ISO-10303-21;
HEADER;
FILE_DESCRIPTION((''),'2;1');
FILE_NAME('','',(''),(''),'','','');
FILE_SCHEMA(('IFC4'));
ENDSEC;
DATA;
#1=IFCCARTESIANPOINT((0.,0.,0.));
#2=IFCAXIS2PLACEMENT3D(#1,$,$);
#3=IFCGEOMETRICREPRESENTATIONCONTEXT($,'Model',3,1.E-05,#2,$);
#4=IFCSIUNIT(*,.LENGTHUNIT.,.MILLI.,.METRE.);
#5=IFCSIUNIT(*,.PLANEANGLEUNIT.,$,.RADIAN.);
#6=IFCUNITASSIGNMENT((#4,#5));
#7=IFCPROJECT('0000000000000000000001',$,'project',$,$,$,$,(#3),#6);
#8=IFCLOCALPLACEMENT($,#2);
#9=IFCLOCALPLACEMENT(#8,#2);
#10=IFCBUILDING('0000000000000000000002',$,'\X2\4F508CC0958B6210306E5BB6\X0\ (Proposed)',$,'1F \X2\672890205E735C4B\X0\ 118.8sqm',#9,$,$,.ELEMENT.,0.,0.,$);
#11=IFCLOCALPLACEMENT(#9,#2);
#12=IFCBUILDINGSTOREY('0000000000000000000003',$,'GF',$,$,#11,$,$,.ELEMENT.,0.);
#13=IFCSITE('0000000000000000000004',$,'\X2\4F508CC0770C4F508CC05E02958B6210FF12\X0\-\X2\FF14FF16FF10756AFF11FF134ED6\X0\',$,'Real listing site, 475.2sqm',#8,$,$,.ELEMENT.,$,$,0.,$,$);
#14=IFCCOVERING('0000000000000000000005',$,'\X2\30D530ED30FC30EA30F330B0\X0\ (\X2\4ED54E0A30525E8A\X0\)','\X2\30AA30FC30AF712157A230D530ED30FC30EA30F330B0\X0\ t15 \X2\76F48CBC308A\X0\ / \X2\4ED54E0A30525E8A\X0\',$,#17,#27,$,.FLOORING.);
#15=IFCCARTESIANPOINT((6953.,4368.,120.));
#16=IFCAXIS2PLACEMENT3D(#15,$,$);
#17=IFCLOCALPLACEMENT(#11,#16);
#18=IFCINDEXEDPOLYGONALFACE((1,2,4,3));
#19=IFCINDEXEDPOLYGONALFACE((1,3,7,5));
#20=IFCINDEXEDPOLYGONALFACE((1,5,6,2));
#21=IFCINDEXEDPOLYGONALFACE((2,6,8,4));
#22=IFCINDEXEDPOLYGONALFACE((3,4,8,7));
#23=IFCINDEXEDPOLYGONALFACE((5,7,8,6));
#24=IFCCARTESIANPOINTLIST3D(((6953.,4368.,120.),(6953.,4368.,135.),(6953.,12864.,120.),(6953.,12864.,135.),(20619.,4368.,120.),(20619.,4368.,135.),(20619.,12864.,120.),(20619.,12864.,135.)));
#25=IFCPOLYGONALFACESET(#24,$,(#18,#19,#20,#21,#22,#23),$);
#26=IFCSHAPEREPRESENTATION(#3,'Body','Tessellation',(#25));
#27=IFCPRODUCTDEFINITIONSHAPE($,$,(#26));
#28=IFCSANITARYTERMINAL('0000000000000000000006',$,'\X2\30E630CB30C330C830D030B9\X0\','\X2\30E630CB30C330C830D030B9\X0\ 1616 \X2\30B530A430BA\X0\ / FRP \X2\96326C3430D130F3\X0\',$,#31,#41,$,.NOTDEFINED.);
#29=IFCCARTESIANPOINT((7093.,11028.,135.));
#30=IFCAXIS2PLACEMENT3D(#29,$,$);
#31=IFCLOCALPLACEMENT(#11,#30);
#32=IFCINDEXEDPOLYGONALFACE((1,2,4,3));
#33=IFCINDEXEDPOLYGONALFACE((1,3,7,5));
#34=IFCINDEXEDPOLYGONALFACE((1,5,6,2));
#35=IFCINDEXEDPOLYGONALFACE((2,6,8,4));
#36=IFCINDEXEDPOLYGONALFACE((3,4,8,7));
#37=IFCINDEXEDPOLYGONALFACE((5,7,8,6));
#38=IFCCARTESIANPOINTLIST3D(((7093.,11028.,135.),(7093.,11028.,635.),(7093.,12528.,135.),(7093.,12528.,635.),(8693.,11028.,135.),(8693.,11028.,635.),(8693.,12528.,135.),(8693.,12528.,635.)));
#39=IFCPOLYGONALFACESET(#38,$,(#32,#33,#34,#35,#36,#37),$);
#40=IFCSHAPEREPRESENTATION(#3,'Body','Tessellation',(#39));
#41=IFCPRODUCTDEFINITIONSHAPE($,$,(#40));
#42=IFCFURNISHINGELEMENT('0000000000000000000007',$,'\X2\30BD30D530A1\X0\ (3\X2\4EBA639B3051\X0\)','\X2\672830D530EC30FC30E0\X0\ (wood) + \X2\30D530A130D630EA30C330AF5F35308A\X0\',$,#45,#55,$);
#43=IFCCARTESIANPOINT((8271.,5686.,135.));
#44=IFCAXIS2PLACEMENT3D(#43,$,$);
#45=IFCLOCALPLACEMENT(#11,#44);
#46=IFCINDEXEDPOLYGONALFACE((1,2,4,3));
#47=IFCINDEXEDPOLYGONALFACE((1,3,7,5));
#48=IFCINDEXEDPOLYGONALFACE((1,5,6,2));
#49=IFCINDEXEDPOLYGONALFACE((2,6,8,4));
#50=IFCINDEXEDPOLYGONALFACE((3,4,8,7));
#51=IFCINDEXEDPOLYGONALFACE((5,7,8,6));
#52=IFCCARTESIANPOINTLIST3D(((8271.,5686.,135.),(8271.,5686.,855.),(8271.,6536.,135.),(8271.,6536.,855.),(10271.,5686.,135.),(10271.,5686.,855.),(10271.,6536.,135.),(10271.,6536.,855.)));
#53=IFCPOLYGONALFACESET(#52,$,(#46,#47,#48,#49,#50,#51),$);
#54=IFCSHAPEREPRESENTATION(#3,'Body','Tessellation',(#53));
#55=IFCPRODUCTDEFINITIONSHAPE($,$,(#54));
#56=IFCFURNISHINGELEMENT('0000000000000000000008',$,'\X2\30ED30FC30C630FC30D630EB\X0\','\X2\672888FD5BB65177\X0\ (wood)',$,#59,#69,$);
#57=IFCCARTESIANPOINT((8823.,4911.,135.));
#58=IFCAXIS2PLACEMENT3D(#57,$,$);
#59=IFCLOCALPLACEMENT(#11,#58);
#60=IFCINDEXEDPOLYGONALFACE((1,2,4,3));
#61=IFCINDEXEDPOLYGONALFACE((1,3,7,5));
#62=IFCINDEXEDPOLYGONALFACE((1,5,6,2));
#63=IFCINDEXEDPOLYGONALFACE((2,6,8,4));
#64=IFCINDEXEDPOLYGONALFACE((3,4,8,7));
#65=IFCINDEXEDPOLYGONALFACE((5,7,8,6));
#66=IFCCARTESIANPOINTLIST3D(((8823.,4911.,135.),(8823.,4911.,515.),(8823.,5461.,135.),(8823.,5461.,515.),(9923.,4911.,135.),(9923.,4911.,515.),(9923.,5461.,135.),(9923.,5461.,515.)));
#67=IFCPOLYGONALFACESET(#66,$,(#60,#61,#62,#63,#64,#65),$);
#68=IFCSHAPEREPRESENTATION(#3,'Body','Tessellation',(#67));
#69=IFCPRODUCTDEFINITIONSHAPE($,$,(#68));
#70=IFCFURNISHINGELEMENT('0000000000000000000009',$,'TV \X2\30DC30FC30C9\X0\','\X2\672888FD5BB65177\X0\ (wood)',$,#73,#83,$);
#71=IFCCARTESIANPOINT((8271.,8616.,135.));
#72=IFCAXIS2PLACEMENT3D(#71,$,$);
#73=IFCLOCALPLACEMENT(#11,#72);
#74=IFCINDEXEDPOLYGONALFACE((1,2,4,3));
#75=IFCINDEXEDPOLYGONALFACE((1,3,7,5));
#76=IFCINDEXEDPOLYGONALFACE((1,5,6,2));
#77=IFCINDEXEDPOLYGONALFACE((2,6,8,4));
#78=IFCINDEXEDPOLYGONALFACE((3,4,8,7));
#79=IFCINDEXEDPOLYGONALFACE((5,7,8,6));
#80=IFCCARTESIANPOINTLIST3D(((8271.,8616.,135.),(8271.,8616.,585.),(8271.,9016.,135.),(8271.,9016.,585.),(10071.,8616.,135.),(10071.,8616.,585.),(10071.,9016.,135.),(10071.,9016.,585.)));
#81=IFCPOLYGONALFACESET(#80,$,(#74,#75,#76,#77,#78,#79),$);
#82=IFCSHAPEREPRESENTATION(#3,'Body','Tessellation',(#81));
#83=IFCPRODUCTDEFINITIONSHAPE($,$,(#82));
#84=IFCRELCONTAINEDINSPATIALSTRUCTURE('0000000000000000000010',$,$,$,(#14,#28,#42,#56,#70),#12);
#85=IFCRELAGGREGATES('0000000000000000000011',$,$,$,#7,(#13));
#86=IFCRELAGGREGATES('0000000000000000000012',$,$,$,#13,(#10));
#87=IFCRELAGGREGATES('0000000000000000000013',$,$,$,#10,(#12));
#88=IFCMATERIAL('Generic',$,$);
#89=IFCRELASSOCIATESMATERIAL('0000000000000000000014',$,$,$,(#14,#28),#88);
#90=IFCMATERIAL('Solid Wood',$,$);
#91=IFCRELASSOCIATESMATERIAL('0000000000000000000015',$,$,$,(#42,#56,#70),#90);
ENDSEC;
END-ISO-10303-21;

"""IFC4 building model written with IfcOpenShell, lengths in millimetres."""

from ifc_helpers import new_model, si_unit, frame, frame_2d, origin, place, context, project, spatial, rectangle, extrude, material, element, save


model = new_model("IFC4")

# Units and contexts
model_context = context("Model", 3, precision=1e-05, world=origin())
ifc_project = project(units=[si_unit("LENGTHUNIT", "METRE", prefix="MILLI"), si_unit("PLANEANGLEUNIT", "RADIAN")], contexts=[model_context])

# Site, building, storey
site_placement = place(None, origin())
site = spatial("IfcSite", under=ifc_project, at=site_placement, Name="佐賀県佐賀市開成２-４６０番１３他", ObjectType="Real listing site, 475.2sqm", CompositionType="ELEMENT", RefElevation=0.0)
building_placement = place(site_placement, origin())
building = spatial("IfcBuilding", under=site, at=building_placement, Name="佐賀開成の家 (Proposed)", ObjectType="1F 木造平屋 118.8sqm", CompositionType="ELEMENT", ElevationOfRefHeight=0.0, ElevationOfTerrain=0.0)
storey_placement = place(building_placement, origin())
storey = spatial("IfcBuildingStorey", under=building, at=storey_placement, Name="GF", CompositionType="ELEMENT", Elevation=0.0)

# Shared definitions
ifc_material_1 = material(Name="Solid Wood")

# Covering
ifc_material_2 = material(Name="Generic")
covering_placement = place(storey_placement, frame((6953.0, 4368.0, 120.0)))
element("IfcCovering", 1, at=covering_placement, inside=storey, material=ifc_material_2, Name="フローリング (仕上げ床)", Description="オーク無垢フローリング t15 直貼り / 仕上げ床", PredefinedType="FLOORING", context=model_context, shape_type="SweptSolid", body=[
    extrude(rectangle(XDim=13666.0, YDim=8496.0, at=frame_2d((6833.0, 4248.0))), frame((6953.0, 4368.0, 120.0)), (0.0, 0.0, 1.0), 15.0),
])

# Sanitary terminal
sanitary_terminal_placement = place(storey_placement, frame((7093.0, 11028.0, 135.0)))
element("IfcSanitaryTerminal", 2, at=sanitary_terminal_placement, inside=storey, material=ifc_material_2, Name="ユニットバス", Description="ユニットバス 1616 サイズ / FRP 防水パン", PredefinedType="NOTDEFINED", context=model_context, shape_type="SweptSolid", body=[
    extrude(rectangle(XDim=1600.0, YDim=1500.0, at=frame_2d((800.0, 750.0))), frame((7093.0, 11028.0, 135.0)), (0.0, 0.0, 1.0), 500.0),
])

# Furnishing elements
furnishing_1_placement = place(storey_placement, frame((8271.0, 5686.0, 135.0)))
element("IfcFurnishingElement", 3, at=furnishing_1_placement, inside=storey, material=ifc_material_1, Name="ソファ (3人掛け)", Description="木フレーム (wood) + ファブリック張り", context=model_context, shape_type="SweptSolid", body=[
    extrude(rectangle(XDim=2000.0, YDim=850.0, at=frame_2d((1000.0, 425.0))), frame((8271.0, 5686.0, 135.0)), (0.0, 0.0, 1.0), 720.0),
])
furnishing_2_placement = place(storey_placement, frame((8823.0, 4911.0, 135.0)))
element("IfcFurnishingElement", 4, at=furnishing_2_placement, inside=storey, material=ifc_material_1, Name="ローテーブル", Description="木製家具 (wood)", context=model_context, shape_type="SweptSolid", body=[
    extrude(rectangle(XDim=1100.0, YDim=550.0, at=frame_2d((550.0, 275.0))), frame((8823.0, 4911.0, 135.0)), (0.0, 0.0, 1.0), 380.0),
])
furnishing_3_placement = place(storey_placement, frame((8271.0, 8616.0, 135.0)))
element("IfcFurnishingElement", 5, at=furnishing_3_placement, inside=storey, material=ifc_material_1, Name="TV ボード", Description="木製家具 (wood)", context=model_context, shape_type="SweptSolid", body=[
    extrude(rectangle(XDim=1800.0, YDim=400.0, at=frame_2d((900.0, 200.0))), frame((8271.0, 8616.0, 135.0)), (0.0, 0.0, 1.0), 450.0),
])

save(model, "model.ifc")
